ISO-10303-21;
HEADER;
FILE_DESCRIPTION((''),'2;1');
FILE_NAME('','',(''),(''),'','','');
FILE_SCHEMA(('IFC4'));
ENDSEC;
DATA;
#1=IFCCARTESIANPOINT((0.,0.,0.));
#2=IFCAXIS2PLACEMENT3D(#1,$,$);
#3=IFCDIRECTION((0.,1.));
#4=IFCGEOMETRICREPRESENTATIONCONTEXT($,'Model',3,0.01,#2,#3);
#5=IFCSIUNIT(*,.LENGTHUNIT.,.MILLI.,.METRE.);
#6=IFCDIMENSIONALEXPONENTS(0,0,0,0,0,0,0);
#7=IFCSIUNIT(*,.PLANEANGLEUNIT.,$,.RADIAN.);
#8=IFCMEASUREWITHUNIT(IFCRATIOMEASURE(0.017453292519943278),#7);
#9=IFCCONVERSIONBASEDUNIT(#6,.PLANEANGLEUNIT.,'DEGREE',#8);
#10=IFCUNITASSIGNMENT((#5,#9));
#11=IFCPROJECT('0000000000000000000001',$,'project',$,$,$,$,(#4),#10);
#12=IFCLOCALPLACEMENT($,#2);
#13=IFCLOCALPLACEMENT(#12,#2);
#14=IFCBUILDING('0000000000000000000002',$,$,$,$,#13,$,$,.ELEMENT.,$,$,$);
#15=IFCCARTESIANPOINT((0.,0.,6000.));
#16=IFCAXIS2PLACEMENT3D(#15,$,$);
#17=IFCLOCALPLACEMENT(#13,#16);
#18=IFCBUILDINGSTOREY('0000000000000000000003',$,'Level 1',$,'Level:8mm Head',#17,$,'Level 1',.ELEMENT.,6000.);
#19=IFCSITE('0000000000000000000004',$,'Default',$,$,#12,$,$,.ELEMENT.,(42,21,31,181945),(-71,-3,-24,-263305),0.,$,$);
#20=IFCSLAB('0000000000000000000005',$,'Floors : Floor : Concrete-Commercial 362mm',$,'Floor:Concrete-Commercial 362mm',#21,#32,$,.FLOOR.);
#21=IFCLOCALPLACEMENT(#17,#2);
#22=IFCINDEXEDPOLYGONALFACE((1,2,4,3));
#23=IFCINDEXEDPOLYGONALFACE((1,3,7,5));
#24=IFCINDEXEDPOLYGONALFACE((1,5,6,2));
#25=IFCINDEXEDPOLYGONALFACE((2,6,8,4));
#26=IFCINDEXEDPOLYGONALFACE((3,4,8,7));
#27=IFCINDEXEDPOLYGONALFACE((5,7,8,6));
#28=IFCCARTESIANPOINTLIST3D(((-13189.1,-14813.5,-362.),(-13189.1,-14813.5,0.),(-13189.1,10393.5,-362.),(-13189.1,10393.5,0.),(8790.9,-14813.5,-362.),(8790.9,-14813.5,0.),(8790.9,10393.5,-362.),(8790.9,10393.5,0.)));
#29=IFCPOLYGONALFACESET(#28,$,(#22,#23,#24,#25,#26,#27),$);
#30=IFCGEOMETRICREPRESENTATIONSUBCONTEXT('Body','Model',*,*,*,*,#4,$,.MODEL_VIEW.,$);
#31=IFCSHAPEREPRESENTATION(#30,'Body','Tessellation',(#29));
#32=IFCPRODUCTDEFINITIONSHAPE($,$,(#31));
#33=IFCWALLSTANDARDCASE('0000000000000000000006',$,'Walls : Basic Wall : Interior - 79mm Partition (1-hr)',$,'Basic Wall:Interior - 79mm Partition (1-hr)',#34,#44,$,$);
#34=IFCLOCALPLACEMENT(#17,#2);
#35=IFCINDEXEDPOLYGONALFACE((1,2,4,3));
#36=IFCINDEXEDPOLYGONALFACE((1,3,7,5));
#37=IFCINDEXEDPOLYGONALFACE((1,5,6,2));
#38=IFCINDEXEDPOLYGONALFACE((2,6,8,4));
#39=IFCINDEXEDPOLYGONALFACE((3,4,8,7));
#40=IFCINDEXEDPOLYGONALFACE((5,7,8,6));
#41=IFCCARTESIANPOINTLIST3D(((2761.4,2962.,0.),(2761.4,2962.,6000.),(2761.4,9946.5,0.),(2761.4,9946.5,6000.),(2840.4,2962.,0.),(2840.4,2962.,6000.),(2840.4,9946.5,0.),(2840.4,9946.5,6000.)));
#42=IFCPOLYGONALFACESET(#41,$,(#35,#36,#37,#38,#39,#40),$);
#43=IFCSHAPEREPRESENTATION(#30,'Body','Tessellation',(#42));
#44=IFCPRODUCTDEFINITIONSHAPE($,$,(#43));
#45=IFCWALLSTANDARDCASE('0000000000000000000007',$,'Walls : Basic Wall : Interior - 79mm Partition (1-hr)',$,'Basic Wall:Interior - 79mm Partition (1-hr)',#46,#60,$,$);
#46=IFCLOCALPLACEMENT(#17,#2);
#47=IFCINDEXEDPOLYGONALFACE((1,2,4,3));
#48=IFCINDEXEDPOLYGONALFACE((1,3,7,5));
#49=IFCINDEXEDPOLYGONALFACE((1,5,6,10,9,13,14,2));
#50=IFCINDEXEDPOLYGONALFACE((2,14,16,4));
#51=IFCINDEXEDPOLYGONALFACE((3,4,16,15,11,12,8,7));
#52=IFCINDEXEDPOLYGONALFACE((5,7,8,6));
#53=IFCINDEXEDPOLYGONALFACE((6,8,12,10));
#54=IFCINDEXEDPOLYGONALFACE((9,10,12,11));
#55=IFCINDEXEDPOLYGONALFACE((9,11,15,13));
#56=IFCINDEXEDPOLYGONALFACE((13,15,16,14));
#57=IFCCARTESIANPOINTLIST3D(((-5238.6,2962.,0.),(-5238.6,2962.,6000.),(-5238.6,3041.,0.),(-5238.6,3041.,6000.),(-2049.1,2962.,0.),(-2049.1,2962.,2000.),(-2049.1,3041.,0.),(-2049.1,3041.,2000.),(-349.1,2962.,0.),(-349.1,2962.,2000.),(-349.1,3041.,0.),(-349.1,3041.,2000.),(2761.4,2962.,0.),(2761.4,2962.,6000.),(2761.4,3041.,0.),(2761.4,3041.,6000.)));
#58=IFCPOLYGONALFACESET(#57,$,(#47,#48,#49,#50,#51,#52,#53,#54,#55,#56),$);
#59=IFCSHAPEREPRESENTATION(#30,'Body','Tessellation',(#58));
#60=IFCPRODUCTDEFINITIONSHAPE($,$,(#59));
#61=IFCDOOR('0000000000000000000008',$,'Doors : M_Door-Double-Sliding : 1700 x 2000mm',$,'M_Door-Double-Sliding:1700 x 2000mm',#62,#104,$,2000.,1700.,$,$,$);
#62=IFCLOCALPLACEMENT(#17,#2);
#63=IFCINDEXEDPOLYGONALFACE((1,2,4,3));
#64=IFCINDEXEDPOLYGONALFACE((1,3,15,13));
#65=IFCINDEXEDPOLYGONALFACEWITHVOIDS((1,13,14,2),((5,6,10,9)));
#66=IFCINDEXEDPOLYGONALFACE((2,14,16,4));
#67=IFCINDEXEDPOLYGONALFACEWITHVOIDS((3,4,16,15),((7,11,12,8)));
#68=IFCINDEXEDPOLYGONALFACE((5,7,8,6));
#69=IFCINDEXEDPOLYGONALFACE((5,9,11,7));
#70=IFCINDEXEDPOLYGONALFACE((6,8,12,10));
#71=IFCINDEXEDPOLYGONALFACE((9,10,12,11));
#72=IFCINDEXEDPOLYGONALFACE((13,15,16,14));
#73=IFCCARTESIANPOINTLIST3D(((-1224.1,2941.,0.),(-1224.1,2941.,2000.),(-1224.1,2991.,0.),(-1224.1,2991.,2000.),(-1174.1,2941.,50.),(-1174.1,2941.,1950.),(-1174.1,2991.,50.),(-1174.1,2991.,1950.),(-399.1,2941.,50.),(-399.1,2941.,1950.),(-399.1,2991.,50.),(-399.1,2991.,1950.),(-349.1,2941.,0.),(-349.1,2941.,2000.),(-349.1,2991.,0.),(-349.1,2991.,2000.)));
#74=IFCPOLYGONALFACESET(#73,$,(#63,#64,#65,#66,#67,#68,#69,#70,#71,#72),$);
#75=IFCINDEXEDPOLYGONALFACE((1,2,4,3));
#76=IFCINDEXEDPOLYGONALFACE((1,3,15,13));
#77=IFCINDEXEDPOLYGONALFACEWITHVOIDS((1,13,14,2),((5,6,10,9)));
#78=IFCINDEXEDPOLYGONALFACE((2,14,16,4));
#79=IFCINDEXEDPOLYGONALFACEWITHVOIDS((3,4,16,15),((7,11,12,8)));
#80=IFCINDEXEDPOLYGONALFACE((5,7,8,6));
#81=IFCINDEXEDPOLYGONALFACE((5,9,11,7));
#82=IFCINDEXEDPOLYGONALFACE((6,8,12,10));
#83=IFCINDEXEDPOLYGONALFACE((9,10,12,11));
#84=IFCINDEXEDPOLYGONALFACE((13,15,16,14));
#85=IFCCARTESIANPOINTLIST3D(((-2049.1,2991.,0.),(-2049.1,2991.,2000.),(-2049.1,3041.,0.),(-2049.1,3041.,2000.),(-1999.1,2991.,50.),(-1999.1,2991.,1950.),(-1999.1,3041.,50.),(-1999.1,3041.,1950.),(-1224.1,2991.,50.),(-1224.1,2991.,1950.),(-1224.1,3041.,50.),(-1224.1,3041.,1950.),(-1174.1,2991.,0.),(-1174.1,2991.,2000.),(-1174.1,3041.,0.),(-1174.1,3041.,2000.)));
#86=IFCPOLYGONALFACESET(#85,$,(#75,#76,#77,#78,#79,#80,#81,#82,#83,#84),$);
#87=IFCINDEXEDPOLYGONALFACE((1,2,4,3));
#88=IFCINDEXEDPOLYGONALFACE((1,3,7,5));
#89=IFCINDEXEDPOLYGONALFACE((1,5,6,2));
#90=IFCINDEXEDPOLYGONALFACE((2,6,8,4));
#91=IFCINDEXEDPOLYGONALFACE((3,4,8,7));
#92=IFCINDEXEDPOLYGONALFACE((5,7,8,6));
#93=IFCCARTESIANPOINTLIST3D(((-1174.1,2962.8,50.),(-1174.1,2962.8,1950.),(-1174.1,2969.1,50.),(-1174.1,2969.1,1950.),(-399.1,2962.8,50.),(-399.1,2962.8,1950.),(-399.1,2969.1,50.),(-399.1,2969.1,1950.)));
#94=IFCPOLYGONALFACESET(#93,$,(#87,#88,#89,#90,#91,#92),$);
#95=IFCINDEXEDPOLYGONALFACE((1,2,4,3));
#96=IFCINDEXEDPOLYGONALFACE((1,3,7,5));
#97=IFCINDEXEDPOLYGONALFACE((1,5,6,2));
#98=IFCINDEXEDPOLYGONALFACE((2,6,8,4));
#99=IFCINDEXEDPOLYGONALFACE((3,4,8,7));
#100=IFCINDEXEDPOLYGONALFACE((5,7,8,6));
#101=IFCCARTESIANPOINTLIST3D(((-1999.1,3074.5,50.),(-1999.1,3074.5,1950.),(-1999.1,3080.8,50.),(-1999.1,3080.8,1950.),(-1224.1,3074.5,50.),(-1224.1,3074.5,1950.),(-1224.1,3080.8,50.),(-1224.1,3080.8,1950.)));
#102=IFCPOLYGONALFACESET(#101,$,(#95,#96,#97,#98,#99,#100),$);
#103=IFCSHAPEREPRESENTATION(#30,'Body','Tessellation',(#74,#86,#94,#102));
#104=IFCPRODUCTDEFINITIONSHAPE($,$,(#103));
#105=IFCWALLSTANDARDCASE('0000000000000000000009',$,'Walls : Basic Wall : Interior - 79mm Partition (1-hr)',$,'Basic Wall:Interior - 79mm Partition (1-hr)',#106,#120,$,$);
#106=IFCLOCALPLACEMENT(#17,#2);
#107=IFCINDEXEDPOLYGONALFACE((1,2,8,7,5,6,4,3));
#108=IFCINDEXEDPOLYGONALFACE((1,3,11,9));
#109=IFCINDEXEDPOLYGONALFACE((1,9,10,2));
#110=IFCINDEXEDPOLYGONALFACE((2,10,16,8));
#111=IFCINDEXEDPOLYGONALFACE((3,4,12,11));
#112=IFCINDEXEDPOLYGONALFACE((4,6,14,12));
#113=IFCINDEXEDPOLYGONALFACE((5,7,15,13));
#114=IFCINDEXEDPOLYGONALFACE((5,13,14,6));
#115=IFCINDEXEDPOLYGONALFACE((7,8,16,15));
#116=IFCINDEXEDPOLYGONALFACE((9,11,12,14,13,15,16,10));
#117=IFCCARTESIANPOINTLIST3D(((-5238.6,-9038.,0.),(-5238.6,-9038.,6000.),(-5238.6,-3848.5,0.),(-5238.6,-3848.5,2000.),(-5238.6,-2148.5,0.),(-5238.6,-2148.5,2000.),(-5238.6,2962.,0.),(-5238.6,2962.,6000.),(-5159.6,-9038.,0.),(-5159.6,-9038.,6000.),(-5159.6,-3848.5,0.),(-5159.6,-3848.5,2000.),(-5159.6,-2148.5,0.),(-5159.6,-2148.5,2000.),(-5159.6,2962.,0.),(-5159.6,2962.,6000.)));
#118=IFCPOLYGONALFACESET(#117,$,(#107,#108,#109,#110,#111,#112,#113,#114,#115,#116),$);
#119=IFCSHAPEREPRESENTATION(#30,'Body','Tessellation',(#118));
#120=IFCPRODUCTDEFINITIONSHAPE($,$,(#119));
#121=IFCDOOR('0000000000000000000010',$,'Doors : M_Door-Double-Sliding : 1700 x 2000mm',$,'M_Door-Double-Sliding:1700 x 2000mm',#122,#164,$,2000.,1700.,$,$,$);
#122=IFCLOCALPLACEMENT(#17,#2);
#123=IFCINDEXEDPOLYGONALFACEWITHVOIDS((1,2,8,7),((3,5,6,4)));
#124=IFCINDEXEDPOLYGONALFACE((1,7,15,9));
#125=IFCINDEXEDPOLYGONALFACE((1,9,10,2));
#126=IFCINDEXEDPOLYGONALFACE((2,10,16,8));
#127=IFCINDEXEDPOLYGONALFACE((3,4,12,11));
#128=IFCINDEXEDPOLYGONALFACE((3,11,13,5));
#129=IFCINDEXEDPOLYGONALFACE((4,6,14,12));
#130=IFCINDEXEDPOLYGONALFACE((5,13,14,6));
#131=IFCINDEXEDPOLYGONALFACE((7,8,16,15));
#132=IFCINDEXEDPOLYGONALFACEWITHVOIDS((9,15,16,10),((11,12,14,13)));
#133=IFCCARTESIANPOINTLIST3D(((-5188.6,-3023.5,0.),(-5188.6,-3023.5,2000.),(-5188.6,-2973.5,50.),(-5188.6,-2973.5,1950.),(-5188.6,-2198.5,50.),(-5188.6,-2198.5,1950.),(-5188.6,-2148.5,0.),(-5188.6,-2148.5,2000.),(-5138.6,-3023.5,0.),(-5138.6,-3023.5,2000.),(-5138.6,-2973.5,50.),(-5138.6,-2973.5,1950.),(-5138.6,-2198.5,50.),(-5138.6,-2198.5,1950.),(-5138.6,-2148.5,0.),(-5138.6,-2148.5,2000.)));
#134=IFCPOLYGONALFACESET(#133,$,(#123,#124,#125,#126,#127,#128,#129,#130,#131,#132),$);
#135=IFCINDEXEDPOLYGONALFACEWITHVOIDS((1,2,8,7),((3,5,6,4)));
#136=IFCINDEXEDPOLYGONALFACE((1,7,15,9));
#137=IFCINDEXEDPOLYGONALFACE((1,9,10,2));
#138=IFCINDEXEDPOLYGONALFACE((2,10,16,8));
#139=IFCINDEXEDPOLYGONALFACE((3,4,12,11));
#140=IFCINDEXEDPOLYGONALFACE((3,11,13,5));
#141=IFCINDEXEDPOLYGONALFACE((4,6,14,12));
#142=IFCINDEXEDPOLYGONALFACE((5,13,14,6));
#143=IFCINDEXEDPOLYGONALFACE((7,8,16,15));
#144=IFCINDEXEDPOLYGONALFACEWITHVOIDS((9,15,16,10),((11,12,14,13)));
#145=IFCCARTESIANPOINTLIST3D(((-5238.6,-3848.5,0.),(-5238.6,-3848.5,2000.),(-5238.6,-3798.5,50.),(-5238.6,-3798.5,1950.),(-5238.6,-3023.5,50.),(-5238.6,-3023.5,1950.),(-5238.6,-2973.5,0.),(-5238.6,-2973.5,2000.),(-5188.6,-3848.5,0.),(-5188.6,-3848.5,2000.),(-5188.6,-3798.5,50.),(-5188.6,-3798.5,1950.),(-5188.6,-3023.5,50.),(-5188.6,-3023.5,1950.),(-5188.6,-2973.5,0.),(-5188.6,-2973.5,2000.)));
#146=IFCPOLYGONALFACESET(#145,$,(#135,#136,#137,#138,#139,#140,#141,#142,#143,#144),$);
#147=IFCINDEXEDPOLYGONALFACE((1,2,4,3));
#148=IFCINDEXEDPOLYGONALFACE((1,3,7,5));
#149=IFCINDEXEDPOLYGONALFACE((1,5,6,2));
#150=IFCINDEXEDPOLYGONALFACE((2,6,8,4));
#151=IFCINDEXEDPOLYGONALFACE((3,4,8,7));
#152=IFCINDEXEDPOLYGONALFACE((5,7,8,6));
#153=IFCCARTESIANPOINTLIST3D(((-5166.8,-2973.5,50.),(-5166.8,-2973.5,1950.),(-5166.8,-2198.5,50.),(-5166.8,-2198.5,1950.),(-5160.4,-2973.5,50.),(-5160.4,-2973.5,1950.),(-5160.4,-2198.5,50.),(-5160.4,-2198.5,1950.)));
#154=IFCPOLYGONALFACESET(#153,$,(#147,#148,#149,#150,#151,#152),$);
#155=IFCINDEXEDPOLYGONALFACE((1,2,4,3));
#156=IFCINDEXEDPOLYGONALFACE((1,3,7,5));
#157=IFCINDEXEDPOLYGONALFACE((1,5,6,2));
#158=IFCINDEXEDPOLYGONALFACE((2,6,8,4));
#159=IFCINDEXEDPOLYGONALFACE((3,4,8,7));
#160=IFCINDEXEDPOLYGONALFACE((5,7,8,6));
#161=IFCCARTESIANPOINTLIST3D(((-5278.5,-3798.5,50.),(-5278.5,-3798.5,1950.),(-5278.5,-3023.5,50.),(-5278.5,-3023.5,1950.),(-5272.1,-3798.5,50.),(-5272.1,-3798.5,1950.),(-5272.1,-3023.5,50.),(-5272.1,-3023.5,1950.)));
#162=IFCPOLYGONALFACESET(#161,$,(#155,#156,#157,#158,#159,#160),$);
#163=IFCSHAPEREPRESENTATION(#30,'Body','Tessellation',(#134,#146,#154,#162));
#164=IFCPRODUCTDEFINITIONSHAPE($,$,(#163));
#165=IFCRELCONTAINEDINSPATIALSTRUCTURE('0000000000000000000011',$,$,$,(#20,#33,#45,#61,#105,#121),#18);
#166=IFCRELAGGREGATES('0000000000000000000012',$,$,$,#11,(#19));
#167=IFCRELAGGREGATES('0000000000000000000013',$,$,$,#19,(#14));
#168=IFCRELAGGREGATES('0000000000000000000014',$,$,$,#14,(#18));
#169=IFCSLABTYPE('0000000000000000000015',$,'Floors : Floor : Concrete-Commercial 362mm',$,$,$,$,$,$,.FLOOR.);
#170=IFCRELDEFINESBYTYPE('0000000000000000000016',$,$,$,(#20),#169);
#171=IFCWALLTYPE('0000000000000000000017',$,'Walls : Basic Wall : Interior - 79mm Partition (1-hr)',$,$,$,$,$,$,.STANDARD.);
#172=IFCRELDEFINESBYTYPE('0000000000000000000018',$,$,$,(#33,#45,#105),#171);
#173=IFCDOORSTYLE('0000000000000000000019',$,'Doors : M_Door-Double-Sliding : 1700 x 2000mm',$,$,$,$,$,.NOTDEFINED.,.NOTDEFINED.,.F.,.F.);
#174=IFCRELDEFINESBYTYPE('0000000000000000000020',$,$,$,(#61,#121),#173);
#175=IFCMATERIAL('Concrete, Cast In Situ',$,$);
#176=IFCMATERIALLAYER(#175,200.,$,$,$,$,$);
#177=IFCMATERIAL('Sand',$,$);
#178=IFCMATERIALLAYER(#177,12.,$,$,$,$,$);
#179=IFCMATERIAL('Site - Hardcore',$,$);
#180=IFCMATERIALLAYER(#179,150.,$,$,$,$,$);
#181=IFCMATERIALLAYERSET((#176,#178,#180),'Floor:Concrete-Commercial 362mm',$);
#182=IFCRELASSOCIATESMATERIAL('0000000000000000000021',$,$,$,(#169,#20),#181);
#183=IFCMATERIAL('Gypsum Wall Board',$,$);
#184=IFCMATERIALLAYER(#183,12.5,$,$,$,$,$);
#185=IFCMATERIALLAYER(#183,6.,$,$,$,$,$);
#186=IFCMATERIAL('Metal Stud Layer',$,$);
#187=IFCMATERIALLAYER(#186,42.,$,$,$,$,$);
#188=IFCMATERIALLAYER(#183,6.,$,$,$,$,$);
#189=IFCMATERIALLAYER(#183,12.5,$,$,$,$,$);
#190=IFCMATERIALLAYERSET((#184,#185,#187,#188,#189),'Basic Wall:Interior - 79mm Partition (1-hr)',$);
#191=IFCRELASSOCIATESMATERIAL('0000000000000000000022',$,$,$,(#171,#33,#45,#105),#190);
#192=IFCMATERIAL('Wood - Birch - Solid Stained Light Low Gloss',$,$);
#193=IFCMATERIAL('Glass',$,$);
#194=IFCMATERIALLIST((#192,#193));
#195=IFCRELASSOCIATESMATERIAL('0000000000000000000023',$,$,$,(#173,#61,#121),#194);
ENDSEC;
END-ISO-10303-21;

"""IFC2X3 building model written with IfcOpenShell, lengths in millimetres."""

from ifc_helpers import new_model, entity, si_unit, converted_unit, direction, frame, frame_2d, origin, origin_2d_with_axis, place, context, subcontext, project, spatial, polyline, rectangle, outline, extrude, source, transform, mapped, material, material_list, layer, layer_set, layer_usage, type_object, type_shapes, element, fill, save


model = new_model("IFC2X3")

# Units and contexts
model_context = context("Model", 3, precision=0.01, world=origin(), true_north=direction((0.0, 1.0)))
body_context = subcontext(model_context, "Body", "Model", "MODEL_VIEW")
ifc_project = project(units=[si_unit("LENGTHUNIT", "METRE", prefix="MILLI"), converted_unit("PLANEANGLEUNIT", "DEGREE", entity("IfcRatioMeasure", 0.017453292519943278), si_unit("PLANEANGLEUNIT", "RADIAN"), dimensions=[0, 0, 0, 0, 0, 0, 0])], contexts=[model_context])

# Site, building, storey
site_placement = place(None, origin())
site = spatial("IfcSite", under=ifc_project, at=site_placement, Name="Default", CompositionType="ELEMENT", RefLatitude=(42, 21, 31, 181945), RefLongitude=(-71, -3, -24, -263305), RefElevation=0.0)
building_placement = place(site_placement, origin())
building = spatial("IfcBuilding", under=site, at=building_placement, CompositionType="ELEMENT")
storey_placement = place(building_placement, frame((0.0, 0.0, 6000.0)))
storey = spatial("IfcBuildingStorey", under=building, at=storey_placement, Name="Level 1", ObjectType="Level:8mm Head", LongName="Level 1", CompositionType="ELEMENT", Elevation=6000.0)

# Slab
ifc_material_1 = material(Name="Concrete, Cast In Situ")
ifc_layer_1 = layer(ifc_material_1, 200.0)
ifc_material_2 = material(Name="Sand")
ifc_layer_2 = layer(ifc_material_2, 12.0)
ifc_material_3 = material(Name="Site - Hardcore")
ifc_layer_3 = layer(ifc_material_3, 150.0)
ifc_layer_set_1 = layer_set([ifc_layer_1, ifc_layer_2, ifc_layer_3], Name="Floor:Concrete-Commercial 362mm")
ifc_layer_usage_1 = layer_usage(ifc_layer_set_1, "AXIS3", "POSITIVE", 0.0)
slab_type = type_object("IfcSlabType", Name="Floors : Floor : Concrete-Commercial 362mm", PredefinedType="FLOOR", material=ifc_layer_set_1)
slab_placement = place(storey_placement, origin())
element("IfcSlab", 1, at=slab_placement, inside=storey, type_object=slab_type, material=ifc_layer_usage_1, Name="Floors : Floor : Concrete-Commercial 362mm", ObjectType="Floor:Concrete-Commercial 362mm", PredefinedType="FLOOR", context=body_context, shape_type="SweptSolid", body=[
    extrude(rectangle(XDim=25207.0, YDim=21980.0, at=frame_2d((0.0, 0.0), x_axis=(1.0, 0.0))), frame((-2199.1, -2210.0, 0.0), z_axis=(0.0, 0.0, -1.0), x_axis=(0.0, 1.0, 0.0)), (0.0, 0.0, 1.0), 362.0),
])

# Wall
ifc_material_4 = material(Name="Gypsum Wall Board")
ifc_layer_4 = layer(ifc_material_4, 12.5)
ifc_layer_5 = layer(ifc_material_4, 6.0)
ifc_material_5 = material(Name="Metal Stud Layer")
ifc_layer_6 = layer(ifc_material_5, 42.0)
ifc_layer_7 = layer(ifc_material_4, 6.0)
ifc_layer_8 = layer(ifc_material_4, 12.5)
ifc_layer_set_2 = layer_set([ifc_layer_4, ifc_layer_5, ifc_layer_6, ifc_layer_7, ifc_layer_8], Name="Basic Wall:Interior - 79mm Partition (1-hr)")
ifc_layer_usage_2 = layer_usage(ifc_layer_set_2, "AXIS2", "NEGATIVE", 39.5)
wall_type = type_object("IfcWallType", Name="Walls : Basic Wall : Interior - 79mm Partition (1-hr)", PredefinedType="STANDARD", material=ifc_layer_set_2)
wall_1_placement = place(storey_placement, frame((2800.9, 9946.5, 0.0), z_axis=(0.0, 0.0, 1.0), x_axis=(0.0, -1.0, 0.0)))
element("IfcWallStandardCase", 2, at=wall_1_placement, inside=storey, type_object=wall_type, material=ifc_layer_usage_2, Name="Walls : Basic Wall : Interior - 79mm Partition (1-hr)", ObjectType="Basic Wall:Interior - 79mm Partition (1-hr)", context=body_context, shape_type="SweptSolid", body=[
    extrude(rectangle(XDim=6984.5, YDim=79.0, at=frame_2d((3492.3, 0.0), x_axis=(-1.0, 0.0))), origin(), (0.0, 0.0, 1.0), 6000.0),
])

# Walls, openings, doors
wall_2_placement = place(storey_placement, frame((2761.4, 3001.5, 0.0), z_axis=(0.0, 0.0, 1.0), x_axis=(-1.0, 0.0, 0.0)))
wall_2 = element("IfcWallStandardCase", 3, at=wall_2_placement, inside=storey, type_object=wall_type, material=ifc_layer_usage_2, Name="Walls : Basic Wall : Interior - 79mm Partition (1-hr)", ObjectType="Basic Wall:Interior - 79mm Partition (1-hr)", context=body_context, shape_type="SweptSolid", body=[
    extrude(rectangle(XDim=8000.0, YDim=79.0, at=frame_2d((4000.0, 0.0), x_axis=(-1.0, 0.0))), origin(), (0.0, 0.0, 1.0), 6000.0),
])
opening_1_placement = place(wall_2_placement, frame((4810.5, 39.5, 0.0)))
opening_1 = element("IfcOpeningElement", 4, at=opening_1_placement, cuts=wall_2, ObjectType="Opening", context=body_context, shape_type="SweptSolid", body=[
    extrude(rectangle(XDim=2000.0, YDim=1700.0, at=frame_2d((1000.0, 850.0), x_axis=(-1.0, 0.0))), frame((0.0, 0.0, 0.0), z_axis=(0.0, -1.0, 0.0), x_axis=(0.0, 0.0, 1.0)), (0.0, 0.0, 1.0), 79.0),
])
ifc_material_6 = material(Name="Wood - Birch - Solid Stained Light Low Gloss")
ifc_material_7 = material(Name="Glass")
ifc_material_list = material_list([ifc_material_6, ifc_material_7])
door_style = type_object("IfcDoorStyle", Name="Doors : M_Door-Double-Sliding : 1700 x 2000mm", ConstructionType="NOTDEFINED", OperationType="NOTDEFINED", ParameterTakesPrecedence=False, Sizeable=False, material=ifc_material_list)
shared_shape = source(origin(), body_context, "Body", "SweptSolid", [
    extrude(outline(polyline([(-437.5, -1000.0), (437.5, -1000.0), (437.5, 1000.0), (-437.5, 1000.0), (-437.5, -1000.0)]), holes=[polyline([(-387.5, -950.0), (-387.5, 950.0), (387.5, 950.0), (387.5, -950.0), (-387.5, -950.0)])]), frame((1262.5, -21.0, 1000.0), z_axis=(0.0, 1.0, 0.0), x_axis=(1.0, 0.0, 0.0)), (0.0, 0.0, 1.0), 50.0),
    extrude(outline(polyline([(-1000.0, -437.5), (1000.0, -437.5), (1000.0, 437.5), (-1000.0, 437.5), (-1000.0, -437.5)]), holes=[polyline([(-950.0, -387.5), (-950.0, 387.5), (950.0, 387.5), (950.0, -387.5), (-950.0, -387.5)])]), frame((437.5, 29.0, 1000.0), z_axis=(0.0, 1.0, 0.0), x_axis=(0.0, 0.0, -1.0)), (0.0, 0.0, 1.0), 50.0),
    extrude(rectangle(XDim=6.3, YDim=775.0, at=frame_2d((0.0, 0.0), x_axis=(1.0, 0.0))), frame((1262.5, 4.0, 50.0), z_axis=(0.0, 0.0, 1.0), x_axis=(0.0, -1.0, 0.0)), (0.0, 0.0, 1.0), 1900.0),
    extrude(rectangle(XDim=6.4, YDim=775.0, at=origin_2d_with_axis()), frame((437.5, 115.7, 50.0), z_axis=(0.0, 0.0, 1.0), x_axis=(0.0, 1.0, 0.0)), (0.0, 0.0, 1.0), 1900.0),
])
type_shapes(door_style, [shared_shape])
door_1_placement = place(opening_1_placement, frame((0.0, 0.0, 0.0), z_axis=(0.0, 0.0, 1.0), x_axis=(-1.0, 0.0, 0.0)))
door_1 = element("IfcDoor", 5, at=door_1_placement, inside=storey, type_object=door_style, material=ifc_material_list, Name="Doors : M_Door-Double-Sliding : 1700 x 2000mm", ObjectType="M_Door-Double-Sliding:1700 x 2000mm", OverallHeight=2000.0, OverallWidth=1700.0, context=body_context, shape_type="MappedRepresentation", body=[
    mapped(shared_shape, transform((0.0, 0.0, 0.0), scale=1.0)),
])
fill(opening_1, door_1)
wall_3_placement = place(storey_placement, frame((-5199.1, 2962.0, 0.0), z_axis=(0.0, 0.0, 1.0), x_axis=(0.0, -1.0, 0.0)))
wall_3 = element("IfcWallStandardCase", 6, at=wall_3_placement, inside=storey, type_object=wall_type, material=ifc_layer_usage_2, Name="Walls : Basic Wall : Interior - 79mm Partition (1-hr)", ObjectType="Basic Wall:Interior - 79mm Partition (1-hr)", context=body_context, shape_type="SweptSolid", body=[
    extrude(rectangle(XDim=12000.0, YDim=79.0, at=frame_2d((6000.0, 0.0), x_axis=(1.0, 0.0))), origin(), (0.0, 0.0, 1.0), 6000.0),
])
opening_2_placement = place(wall_3_placement, frame((6810.5, 39.5, 0.0)))
opening_2 = element("IfcOpeningElement", 7, at=opening_2_placement, cuts=wall_3, ObjectType="Opening", context=body_context, shape_type="SweptSolid", body=[
    extrude(rectangle(XDim=2000.0, YDim=1700.0, at=frame_2d((1000.0, 850.0), x_axis=(-1.0, 0.0))), frame((0.0, 0.0, 0.0), z_axis=(0.0, -1.0, 0.0), x_axis=(0.0, 0.0, 1.0)), (0.0, 0.0, 1.0), 79.0),
])
door_2_placement = place(opening_2_placement, frame((0.0, 0.0, 0.0), z_axis=(0.0, 0.0, 1.0), x_axis=(-1.0, 0.0, 0.0)))
door_2 = element("IfcDoor", 8, at=door_2_placement, inside=storey, type_object=door_style, material=ifc_material_list, Name="Doors : M_Door-Double-Sliding : 1700 x 2000mm", ObjectType="M_Door-Double-Sliding:1700 x 2000mm", OverallHeight=2000.0, OverallWidth=1700.0, context=body_context, shape_type="MappedRepresentation", body=[
    mapped(shared_shape, transform((0.0, 0.0, 0.0), scale=1.0)),
])
fill(opening_2, door_2)

save(model, "model.ifc")
